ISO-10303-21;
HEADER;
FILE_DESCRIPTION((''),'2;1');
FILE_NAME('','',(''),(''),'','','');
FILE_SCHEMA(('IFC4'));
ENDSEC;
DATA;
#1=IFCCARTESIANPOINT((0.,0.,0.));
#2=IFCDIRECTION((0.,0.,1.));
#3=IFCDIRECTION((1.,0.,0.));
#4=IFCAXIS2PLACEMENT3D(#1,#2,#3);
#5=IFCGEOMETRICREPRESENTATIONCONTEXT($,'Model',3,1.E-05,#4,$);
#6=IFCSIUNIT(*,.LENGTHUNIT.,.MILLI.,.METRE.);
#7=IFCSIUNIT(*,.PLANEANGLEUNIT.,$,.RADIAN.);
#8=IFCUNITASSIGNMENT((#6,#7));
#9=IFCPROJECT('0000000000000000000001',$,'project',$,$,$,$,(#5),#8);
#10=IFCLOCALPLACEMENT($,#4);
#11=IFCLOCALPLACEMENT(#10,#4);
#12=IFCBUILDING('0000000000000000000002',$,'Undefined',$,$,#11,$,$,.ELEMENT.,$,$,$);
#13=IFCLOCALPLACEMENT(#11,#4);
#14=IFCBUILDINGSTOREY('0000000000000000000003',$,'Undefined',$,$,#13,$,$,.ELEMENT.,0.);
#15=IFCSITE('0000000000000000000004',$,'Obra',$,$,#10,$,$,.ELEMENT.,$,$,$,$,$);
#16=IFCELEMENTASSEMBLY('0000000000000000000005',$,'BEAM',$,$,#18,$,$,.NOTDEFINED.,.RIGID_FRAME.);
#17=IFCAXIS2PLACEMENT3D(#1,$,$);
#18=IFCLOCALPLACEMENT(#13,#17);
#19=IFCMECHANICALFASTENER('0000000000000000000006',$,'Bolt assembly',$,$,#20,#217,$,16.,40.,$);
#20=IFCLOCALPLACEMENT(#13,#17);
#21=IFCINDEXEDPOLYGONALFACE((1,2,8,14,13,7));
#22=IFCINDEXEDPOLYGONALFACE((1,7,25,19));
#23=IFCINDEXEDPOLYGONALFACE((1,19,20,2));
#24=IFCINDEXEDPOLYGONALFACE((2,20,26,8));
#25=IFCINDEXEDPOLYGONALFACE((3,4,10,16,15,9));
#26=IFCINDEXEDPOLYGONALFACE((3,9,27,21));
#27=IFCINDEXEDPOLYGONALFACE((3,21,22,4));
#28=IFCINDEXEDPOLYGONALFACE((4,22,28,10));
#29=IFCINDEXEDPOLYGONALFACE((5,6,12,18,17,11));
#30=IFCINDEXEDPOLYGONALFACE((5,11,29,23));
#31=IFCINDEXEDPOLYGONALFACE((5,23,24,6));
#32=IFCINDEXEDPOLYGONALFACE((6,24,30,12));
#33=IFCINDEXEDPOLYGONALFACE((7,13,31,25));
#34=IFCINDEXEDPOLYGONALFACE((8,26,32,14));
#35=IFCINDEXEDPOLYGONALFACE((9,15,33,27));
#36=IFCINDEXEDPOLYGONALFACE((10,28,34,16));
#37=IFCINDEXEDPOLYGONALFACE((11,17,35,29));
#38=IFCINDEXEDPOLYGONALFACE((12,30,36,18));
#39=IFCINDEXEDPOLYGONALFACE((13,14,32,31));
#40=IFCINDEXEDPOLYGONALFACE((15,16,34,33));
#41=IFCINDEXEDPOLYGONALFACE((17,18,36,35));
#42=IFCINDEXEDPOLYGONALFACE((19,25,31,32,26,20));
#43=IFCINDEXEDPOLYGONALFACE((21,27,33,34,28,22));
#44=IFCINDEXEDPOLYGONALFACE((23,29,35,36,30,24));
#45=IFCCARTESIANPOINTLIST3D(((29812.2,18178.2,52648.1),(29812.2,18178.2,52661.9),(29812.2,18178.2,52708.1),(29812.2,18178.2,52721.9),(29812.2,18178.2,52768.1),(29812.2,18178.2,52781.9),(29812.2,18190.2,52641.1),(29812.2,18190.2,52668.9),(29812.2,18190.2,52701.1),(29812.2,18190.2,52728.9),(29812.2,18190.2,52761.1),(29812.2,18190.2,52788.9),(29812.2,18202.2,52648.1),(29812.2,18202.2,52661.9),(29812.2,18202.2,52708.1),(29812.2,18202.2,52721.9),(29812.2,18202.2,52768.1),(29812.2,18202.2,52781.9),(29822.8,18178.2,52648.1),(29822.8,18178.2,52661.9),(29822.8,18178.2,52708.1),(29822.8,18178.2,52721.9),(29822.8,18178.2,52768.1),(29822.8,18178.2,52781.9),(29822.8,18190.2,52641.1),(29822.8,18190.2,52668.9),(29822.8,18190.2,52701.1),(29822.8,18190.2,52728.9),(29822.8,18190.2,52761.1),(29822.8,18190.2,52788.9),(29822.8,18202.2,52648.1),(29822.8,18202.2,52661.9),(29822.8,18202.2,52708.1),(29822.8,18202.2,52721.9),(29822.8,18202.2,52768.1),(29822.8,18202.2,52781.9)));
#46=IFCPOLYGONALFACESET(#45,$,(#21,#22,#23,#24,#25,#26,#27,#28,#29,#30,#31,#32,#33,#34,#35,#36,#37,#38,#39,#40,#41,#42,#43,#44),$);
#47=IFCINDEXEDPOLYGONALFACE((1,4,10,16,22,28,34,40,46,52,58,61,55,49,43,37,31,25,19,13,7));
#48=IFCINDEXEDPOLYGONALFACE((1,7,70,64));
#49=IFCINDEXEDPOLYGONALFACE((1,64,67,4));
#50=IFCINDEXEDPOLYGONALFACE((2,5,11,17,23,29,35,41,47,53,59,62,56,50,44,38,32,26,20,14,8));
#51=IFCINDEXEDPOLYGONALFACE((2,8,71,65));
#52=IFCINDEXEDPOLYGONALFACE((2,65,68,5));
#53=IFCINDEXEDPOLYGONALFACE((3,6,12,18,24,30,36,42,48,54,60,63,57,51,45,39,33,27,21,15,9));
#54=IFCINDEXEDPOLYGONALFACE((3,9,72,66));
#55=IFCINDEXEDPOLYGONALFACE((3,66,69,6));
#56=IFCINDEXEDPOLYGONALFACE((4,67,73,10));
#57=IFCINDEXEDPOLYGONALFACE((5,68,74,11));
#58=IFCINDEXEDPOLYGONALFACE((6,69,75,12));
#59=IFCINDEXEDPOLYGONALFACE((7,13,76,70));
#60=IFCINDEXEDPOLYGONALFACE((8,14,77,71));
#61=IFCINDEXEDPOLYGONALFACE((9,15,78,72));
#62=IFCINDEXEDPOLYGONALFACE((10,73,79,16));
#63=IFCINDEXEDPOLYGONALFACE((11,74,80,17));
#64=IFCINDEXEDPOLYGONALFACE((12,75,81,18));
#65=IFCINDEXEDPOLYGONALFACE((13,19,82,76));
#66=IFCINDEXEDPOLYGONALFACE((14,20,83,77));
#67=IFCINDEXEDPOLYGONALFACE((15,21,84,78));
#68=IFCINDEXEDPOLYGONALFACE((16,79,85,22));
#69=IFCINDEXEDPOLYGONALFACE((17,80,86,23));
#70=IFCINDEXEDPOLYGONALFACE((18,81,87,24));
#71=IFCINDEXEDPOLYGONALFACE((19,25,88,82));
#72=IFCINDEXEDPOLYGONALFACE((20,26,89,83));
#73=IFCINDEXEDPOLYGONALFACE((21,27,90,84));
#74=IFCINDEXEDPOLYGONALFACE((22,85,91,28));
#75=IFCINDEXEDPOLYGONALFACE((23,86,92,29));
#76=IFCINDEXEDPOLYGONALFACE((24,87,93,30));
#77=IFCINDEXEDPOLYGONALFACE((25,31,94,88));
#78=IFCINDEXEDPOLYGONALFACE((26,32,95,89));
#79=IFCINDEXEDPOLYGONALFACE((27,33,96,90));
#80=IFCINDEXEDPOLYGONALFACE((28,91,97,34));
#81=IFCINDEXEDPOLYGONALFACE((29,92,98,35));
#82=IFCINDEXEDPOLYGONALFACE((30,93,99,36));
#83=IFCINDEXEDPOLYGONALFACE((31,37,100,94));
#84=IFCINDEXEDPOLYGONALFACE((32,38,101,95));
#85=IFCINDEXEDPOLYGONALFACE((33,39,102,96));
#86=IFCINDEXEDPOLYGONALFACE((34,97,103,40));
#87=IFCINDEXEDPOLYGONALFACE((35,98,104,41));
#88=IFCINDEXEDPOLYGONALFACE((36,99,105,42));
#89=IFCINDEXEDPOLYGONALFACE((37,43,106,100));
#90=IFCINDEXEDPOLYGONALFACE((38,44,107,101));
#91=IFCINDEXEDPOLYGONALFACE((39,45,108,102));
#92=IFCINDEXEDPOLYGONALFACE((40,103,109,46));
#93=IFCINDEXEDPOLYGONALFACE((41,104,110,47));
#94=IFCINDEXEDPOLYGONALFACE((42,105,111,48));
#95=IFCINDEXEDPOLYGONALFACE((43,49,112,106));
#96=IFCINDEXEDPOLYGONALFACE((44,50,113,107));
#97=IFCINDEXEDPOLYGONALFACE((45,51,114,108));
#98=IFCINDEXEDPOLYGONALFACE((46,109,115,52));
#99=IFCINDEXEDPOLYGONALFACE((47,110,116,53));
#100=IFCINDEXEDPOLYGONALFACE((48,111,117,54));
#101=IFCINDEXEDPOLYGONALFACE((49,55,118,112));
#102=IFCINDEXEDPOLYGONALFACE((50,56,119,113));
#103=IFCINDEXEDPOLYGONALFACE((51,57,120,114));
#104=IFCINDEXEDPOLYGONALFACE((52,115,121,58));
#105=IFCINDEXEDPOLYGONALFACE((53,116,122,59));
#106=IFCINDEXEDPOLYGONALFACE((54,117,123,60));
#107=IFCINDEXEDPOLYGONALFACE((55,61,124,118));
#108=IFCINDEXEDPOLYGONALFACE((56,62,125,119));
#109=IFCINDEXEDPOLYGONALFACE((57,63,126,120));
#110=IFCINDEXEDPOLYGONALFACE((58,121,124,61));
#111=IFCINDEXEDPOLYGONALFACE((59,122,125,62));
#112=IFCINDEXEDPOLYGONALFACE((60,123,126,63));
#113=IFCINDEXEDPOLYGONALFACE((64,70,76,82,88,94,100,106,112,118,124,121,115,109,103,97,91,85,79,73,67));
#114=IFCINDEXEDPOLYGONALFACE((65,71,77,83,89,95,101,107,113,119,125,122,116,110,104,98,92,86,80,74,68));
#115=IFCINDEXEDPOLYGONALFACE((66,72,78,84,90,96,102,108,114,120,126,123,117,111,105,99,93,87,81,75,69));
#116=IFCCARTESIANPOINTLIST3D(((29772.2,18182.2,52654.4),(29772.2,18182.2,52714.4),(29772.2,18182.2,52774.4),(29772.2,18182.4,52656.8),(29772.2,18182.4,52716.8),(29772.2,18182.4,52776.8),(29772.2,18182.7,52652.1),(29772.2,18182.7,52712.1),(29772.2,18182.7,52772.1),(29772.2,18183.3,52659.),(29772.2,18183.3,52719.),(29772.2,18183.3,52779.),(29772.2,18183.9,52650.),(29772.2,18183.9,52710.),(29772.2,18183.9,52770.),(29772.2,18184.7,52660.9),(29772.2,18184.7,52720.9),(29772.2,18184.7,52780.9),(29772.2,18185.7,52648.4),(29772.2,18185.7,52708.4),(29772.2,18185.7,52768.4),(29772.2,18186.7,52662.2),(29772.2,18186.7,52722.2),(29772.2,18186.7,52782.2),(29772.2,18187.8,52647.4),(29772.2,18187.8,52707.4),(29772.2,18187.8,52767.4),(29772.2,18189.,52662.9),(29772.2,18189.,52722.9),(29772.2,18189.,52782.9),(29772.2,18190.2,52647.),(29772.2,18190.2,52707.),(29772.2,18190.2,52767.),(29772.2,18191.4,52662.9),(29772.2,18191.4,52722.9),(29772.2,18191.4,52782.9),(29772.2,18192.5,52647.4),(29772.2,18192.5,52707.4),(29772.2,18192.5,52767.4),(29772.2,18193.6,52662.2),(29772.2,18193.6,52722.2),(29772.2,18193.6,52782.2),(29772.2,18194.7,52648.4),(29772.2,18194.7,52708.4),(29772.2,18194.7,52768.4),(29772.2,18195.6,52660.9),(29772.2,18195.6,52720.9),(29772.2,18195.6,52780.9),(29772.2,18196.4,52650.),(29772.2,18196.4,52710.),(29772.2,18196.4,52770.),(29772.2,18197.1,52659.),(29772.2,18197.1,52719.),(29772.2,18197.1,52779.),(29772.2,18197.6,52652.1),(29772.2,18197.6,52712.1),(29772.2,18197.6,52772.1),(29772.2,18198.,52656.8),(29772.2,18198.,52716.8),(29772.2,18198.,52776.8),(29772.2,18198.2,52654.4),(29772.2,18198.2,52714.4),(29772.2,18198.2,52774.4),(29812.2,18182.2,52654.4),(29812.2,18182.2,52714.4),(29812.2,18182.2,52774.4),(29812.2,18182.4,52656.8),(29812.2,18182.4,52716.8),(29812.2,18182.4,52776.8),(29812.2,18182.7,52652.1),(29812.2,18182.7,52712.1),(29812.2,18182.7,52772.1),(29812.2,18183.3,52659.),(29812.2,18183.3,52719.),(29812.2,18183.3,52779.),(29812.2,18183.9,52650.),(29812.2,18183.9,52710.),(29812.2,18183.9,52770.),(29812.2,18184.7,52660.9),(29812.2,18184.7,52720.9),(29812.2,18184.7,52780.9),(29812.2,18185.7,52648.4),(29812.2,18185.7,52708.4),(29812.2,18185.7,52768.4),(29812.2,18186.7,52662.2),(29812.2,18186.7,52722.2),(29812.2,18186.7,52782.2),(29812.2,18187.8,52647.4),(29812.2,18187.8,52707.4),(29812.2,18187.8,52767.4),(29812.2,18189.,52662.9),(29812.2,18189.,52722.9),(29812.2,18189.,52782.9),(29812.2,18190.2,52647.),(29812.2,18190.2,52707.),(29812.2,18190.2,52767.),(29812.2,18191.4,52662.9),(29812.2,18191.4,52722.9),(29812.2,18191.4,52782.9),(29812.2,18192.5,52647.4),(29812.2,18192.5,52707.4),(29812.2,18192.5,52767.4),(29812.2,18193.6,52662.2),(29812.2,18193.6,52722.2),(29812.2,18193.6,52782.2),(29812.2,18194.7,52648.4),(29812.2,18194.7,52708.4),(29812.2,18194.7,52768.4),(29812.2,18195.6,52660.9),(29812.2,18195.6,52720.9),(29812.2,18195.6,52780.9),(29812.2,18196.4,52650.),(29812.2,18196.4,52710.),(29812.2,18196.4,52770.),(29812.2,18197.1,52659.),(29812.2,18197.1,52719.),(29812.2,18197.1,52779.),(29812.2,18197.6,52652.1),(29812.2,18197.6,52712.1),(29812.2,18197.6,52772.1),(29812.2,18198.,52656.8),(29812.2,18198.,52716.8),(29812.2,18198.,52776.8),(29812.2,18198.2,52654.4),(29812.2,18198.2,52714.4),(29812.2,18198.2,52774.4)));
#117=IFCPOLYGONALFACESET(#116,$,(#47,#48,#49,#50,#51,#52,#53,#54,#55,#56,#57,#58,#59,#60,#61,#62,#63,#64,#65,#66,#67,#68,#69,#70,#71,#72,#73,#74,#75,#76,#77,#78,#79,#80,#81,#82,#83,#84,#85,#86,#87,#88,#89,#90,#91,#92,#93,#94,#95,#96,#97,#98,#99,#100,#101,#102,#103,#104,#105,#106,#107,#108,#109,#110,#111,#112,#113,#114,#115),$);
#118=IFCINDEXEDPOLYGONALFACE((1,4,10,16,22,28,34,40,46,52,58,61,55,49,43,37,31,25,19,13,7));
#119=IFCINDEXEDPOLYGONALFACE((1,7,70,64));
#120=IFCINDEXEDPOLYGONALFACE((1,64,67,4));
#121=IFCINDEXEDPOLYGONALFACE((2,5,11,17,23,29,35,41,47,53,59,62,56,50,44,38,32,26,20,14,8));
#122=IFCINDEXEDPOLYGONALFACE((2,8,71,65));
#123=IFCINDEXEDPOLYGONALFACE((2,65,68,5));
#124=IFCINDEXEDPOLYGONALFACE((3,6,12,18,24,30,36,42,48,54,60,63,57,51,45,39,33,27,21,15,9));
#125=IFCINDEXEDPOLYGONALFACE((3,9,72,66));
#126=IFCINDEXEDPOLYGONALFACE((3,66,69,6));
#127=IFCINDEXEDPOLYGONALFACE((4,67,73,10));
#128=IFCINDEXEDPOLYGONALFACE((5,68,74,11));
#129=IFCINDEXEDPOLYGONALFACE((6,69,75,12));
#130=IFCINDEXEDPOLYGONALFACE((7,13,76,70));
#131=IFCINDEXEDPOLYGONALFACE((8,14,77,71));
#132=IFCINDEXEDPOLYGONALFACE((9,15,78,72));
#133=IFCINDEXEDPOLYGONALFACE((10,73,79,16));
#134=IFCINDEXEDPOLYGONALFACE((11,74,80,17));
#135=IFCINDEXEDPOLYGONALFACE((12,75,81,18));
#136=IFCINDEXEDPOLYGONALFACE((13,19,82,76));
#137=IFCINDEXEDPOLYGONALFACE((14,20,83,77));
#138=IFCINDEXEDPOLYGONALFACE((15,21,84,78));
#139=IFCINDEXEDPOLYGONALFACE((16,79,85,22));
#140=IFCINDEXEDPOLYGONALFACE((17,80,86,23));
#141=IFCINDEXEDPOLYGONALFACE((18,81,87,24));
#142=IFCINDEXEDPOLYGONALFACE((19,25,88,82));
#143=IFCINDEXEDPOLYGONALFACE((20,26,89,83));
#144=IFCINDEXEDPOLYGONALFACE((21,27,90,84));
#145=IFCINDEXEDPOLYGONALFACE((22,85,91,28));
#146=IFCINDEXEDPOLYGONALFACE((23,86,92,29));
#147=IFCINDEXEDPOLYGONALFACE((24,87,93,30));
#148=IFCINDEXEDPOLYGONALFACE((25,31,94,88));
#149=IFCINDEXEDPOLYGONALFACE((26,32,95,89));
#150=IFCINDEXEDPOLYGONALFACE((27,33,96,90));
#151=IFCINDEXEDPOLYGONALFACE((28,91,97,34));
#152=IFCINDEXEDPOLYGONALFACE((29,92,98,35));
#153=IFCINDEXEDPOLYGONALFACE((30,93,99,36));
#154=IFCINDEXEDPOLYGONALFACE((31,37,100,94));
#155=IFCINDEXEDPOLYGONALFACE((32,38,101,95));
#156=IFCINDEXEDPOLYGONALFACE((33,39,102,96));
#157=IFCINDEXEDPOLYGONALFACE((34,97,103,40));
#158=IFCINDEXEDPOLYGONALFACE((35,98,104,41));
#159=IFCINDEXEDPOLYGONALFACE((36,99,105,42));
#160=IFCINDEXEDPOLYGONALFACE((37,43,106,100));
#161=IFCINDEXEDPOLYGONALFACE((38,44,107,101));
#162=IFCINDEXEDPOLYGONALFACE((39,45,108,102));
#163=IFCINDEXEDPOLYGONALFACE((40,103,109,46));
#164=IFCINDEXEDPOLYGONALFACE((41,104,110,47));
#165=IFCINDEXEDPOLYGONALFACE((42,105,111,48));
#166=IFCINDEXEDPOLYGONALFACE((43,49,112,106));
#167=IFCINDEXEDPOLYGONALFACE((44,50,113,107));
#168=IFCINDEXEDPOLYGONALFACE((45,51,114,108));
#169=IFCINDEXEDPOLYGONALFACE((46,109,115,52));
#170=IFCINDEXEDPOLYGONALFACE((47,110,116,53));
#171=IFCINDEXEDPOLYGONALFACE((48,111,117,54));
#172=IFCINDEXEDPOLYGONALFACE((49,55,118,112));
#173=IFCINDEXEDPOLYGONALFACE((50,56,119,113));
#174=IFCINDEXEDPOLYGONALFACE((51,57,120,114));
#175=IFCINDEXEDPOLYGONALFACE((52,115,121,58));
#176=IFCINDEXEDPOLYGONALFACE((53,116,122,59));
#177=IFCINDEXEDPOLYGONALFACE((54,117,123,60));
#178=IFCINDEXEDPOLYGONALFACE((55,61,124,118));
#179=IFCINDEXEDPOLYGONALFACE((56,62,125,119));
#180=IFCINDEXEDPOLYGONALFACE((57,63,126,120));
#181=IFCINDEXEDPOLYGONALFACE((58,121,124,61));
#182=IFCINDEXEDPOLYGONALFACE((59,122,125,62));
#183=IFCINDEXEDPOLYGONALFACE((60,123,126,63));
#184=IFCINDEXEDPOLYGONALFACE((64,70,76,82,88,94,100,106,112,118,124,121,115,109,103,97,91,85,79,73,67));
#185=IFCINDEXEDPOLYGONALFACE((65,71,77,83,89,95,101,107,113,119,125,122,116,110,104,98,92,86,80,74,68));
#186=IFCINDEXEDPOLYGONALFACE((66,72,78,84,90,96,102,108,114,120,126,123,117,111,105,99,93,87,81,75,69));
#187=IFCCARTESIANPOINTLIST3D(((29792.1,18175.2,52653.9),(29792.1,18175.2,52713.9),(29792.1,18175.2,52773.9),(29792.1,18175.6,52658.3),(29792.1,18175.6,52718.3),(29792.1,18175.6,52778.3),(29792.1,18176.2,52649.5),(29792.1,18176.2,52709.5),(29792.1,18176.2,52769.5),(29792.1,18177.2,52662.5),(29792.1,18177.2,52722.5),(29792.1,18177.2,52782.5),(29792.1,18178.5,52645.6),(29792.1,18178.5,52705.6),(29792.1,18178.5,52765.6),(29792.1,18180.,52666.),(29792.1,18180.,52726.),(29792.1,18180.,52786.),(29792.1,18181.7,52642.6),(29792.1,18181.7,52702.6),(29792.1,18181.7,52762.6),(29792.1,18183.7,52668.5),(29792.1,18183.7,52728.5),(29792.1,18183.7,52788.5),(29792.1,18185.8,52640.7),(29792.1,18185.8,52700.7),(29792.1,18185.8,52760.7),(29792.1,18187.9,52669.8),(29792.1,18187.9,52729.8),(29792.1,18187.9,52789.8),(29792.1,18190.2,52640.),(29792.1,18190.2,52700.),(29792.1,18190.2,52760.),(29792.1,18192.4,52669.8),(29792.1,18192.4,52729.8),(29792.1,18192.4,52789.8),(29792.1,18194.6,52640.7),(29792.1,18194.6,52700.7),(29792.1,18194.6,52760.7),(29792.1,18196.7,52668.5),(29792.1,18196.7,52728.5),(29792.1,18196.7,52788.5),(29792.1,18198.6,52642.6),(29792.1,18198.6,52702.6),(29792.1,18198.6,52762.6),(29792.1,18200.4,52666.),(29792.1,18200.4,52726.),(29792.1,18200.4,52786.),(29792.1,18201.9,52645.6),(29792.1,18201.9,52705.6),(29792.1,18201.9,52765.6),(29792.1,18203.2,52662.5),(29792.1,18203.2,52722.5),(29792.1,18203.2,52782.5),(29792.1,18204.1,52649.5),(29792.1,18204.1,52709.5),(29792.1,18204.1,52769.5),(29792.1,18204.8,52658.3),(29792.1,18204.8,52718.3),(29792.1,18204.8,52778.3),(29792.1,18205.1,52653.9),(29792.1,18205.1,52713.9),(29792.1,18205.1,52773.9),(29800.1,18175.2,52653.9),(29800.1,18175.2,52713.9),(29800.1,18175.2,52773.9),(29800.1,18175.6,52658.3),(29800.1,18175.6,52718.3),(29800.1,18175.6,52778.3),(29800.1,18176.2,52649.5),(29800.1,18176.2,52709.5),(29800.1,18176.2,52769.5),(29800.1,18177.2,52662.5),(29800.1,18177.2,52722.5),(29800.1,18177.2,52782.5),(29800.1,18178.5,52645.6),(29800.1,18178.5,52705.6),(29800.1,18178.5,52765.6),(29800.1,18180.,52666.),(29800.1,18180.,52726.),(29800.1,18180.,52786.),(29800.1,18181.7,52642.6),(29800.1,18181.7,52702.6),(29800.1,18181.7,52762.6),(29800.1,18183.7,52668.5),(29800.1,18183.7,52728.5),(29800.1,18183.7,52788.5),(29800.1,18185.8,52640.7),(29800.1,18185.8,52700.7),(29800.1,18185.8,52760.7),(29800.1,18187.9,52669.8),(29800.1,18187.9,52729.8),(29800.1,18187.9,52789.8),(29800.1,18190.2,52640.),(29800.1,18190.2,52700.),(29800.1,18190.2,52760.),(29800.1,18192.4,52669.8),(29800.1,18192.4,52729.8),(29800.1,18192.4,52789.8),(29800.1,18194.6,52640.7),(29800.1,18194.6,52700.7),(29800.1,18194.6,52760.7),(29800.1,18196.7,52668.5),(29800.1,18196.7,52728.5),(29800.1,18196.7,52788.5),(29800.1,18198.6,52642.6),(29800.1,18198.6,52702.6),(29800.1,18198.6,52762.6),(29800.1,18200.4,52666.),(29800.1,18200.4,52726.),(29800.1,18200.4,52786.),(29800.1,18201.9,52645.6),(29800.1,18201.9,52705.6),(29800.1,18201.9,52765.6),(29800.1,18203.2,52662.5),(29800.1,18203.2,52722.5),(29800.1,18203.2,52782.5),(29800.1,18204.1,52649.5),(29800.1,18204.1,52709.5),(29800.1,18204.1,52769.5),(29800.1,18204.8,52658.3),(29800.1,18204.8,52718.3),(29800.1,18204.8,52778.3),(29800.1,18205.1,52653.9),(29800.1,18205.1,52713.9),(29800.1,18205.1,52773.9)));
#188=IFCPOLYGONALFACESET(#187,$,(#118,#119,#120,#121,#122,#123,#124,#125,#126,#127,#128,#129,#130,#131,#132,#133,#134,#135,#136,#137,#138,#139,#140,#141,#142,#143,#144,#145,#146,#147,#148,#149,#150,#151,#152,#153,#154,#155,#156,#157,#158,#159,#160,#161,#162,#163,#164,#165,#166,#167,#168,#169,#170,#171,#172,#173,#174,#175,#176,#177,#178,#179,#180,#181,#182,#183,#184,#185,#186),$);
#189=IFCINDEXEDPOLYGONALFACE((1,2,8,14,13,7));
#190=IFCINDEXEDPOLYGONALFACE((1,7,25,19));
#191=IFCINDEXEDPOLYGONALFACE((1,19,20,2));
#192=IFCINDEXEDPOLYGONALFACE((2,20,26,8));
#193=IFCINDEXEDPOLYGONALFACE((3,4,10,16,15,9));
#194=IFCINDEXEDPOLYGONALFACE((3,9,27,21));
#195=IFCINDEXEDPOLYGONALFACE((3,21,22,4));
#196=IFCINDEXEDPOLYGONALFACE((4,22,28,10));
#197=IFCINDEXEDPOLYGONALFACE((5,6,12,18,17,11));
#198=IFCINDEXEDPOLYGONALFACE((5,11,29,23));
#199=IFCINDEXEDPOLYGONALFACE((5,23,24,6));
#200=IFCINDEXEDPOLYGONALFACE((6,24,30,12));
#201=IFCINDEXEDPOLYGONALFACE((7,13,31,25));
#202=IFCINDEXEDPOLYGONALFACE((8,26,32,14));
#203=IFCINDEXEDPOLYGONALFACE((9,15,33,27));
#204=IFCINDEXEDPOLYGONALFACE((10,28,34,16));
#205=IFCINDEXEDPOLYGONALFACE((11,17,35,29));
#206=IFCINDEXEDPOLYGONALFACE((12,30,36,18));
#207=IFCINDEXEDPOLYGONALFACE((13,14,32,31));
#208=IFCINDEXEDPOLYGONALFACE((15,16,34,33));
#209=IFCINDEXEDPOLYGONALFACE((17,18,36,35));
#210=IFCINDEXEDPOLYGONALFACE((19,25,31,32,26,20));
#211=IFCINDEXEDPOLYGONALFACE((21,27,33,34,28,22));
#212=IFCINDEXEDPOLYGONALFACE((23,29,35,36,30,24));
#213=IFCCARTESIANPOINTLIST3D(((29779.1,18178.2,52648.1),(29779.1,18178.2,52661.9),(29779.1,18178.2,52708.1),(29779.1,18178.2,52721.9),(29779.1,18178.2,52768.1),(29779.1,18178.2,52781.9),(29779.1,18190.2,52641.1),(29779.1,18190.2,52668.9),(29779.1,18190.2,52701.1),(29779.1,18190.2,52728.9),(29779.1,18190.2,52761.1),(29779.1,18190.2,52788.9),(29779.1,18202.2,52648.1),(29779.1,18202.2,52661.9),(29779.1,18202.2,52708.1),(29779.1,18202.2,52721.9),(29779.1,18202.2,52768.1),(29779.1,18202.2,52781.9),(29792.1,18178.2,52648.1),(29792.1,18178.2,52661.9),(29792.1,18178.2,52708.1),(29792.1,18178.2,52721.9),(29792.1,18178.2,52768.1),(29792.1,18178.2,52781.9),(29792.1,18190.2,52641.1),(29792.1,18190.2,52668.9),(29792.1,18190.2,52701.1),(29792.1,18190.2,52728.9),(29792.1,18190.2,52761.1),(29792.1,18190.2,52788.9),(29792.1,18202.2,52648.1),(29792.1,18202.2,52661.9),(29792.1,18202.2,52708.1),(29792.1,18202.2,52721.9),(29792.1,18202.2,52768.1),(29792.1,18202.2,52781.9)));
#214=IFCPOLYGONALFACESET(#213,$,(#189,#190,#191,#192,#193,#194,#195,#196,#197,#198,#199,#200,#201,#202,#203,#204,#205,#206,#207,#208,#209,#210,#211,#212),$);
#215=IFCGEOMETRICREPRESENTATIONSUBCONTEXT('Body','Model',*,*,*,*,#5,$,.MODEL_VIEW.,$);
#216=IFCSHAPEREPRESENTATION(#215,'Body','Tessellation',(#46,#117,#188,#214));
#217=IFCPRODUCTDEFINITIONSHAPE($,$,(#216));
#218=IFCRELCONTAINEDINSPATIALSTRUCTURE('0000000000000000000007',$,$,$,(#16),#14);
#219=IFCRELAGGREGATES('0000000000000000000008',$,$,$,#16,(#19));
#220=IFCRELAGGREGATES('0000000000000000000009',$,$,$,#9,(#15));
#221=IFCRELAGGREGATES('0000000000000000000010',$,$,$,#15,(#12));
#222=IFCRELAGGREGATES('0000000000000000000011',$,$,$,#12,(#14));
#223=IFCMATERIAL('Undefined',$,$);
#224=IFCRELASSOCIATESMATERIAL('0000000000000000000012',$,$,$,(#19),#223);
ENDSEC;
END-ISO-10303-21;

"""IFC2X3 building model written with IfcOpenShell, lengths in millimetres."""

from ifc_helpers import new_model, si_unit, frame, origin_with_axes, origin_2d_with_axis, place, context, subcontext, project, spatial, polyline, circle, outline, extrude, source, transform, mapped, material, element, aggregate, save


model = new_model("IFC2X3")

# Units and contexts
model_context = context("Model", 3, precision=1e-05, world=origin_with_axes())
body_context = subcontext(model_context, "Body", "Model", "MODEL_VIEW")
ifc_project = project(units=[si_unit("LENGTHUNIT", "METRE", prefix="MILLI"), si_unit("PLANEANGLEUNIT", "RADIAN")], contexts=[model_context])

# Site, building, storey
site_placement = place(None, origin_with_axes())
site = spatial("IfcSite", under=ifc_project, at=site_placement, Name="Obra", CompositionType="ELEMENT")
building_placement = place(site_placement, origin_with_axes())
building = spatial("IfcBuilding", under=site, at=building_placement, Name="Undefined", CompositionType="ELEMENT")
storey_placement = place(building_placement, origin_with_axes())
storey = spatial("IfcBuildingStorey", under=building, at=storey_placement, Name="Undefined", CompositionType="ELEMENT", Elevation=0.0)

# Element assembly
assembly_1_placement = place(storey_placement, origin_with_axes())
assembly_1 = element("IfcElementAssembly", 1, at=assembly_1_placement, inside=storey, Name="BEAM", AssemblyPlace="NOTDEFINED", PredefinedType="RIGID_FRAME")

# Mechanical fastener
ifc_material_1 = material(Name="Undefined")
shared_shape_1 = source(origin_with_axes(), body_context, "Body", "SweptSolid", [
    extrude(outline(polyline([(13.9, 0.0), (6.9, 12.0), (-6.9, 12.0), (-13.9, 0.0), (-6.9, -12.0), (6.9, -12.0), (13.9, 0.0)])), frame((0.0, -19.7, 0.0), z_axis=(0.0, 1.0, 0.0), x_axis=(1.0, 0.0, 0.0)), (0.0, 0.0, 1.0), 10.6),
    extrude(circle(Radius=8.0, at=origin_2d_with_axis()), frame((0.0, -9.1, 0.0), z_axis=(0.0, 1.0, 0.0), x_axis=(1.0, 0.0, 0.0)), (0.0, 0.0, 1.0), 40.0),
    extrude(circle(Radius=15.0, at=origin_2d_with_axis()), frame((0.0, 3.0, 0.0), z_axis=(0.0, 1.0, 0.0), x_axis=(1.0, 0.0, 0.0)), (0.0, 0.0, 1.0), 8.0),
    extrude(outline(polyline([(13.9, 0.0), (6.9, 12.0), (-6.9, 12.0), (-13.9, 0.0), (-6.9, -12.0), (6.9, -12.0), (13.9, 0.0)])), frame((0.0, 11.0, 0.0), z_axis=(0.0, 1.0, 0.0), x_axis=(1.0, 0.0, 0.0)), (0.0, 0.0, 1.0), 13.0),
])
mechanical_fastener_1_placement = place(assembly_1_placement, frame((29803.1, 18140.2, 52835.0), z_axis=(-0.000002, 1.0, 0.0), x_axis=(0.0, 0.0, -1.0)))
mechanical_fastener_1 = element("IfcMechanicalFastener", 2, at=mechanical_fastener_1_placement, material=ifc_material_1, Name="Bolt assembly", NominalDiameter=16.0, NominalLength=40.0, context=body_context, shape_type="MappedRepresentation", body=[
    mapped(shared_shape_1, transform((60.0, 0.0, 50.0))),
    mapped(shared_shape_1, transform((120.0, 0.0, 50.0))),
    mapped(shared_shape_1, transform((180.0, 0.0, 50.0))),
])
aggregate(assembly_1, [mechanical_fastener_1])

save(model, "model.ifc")
